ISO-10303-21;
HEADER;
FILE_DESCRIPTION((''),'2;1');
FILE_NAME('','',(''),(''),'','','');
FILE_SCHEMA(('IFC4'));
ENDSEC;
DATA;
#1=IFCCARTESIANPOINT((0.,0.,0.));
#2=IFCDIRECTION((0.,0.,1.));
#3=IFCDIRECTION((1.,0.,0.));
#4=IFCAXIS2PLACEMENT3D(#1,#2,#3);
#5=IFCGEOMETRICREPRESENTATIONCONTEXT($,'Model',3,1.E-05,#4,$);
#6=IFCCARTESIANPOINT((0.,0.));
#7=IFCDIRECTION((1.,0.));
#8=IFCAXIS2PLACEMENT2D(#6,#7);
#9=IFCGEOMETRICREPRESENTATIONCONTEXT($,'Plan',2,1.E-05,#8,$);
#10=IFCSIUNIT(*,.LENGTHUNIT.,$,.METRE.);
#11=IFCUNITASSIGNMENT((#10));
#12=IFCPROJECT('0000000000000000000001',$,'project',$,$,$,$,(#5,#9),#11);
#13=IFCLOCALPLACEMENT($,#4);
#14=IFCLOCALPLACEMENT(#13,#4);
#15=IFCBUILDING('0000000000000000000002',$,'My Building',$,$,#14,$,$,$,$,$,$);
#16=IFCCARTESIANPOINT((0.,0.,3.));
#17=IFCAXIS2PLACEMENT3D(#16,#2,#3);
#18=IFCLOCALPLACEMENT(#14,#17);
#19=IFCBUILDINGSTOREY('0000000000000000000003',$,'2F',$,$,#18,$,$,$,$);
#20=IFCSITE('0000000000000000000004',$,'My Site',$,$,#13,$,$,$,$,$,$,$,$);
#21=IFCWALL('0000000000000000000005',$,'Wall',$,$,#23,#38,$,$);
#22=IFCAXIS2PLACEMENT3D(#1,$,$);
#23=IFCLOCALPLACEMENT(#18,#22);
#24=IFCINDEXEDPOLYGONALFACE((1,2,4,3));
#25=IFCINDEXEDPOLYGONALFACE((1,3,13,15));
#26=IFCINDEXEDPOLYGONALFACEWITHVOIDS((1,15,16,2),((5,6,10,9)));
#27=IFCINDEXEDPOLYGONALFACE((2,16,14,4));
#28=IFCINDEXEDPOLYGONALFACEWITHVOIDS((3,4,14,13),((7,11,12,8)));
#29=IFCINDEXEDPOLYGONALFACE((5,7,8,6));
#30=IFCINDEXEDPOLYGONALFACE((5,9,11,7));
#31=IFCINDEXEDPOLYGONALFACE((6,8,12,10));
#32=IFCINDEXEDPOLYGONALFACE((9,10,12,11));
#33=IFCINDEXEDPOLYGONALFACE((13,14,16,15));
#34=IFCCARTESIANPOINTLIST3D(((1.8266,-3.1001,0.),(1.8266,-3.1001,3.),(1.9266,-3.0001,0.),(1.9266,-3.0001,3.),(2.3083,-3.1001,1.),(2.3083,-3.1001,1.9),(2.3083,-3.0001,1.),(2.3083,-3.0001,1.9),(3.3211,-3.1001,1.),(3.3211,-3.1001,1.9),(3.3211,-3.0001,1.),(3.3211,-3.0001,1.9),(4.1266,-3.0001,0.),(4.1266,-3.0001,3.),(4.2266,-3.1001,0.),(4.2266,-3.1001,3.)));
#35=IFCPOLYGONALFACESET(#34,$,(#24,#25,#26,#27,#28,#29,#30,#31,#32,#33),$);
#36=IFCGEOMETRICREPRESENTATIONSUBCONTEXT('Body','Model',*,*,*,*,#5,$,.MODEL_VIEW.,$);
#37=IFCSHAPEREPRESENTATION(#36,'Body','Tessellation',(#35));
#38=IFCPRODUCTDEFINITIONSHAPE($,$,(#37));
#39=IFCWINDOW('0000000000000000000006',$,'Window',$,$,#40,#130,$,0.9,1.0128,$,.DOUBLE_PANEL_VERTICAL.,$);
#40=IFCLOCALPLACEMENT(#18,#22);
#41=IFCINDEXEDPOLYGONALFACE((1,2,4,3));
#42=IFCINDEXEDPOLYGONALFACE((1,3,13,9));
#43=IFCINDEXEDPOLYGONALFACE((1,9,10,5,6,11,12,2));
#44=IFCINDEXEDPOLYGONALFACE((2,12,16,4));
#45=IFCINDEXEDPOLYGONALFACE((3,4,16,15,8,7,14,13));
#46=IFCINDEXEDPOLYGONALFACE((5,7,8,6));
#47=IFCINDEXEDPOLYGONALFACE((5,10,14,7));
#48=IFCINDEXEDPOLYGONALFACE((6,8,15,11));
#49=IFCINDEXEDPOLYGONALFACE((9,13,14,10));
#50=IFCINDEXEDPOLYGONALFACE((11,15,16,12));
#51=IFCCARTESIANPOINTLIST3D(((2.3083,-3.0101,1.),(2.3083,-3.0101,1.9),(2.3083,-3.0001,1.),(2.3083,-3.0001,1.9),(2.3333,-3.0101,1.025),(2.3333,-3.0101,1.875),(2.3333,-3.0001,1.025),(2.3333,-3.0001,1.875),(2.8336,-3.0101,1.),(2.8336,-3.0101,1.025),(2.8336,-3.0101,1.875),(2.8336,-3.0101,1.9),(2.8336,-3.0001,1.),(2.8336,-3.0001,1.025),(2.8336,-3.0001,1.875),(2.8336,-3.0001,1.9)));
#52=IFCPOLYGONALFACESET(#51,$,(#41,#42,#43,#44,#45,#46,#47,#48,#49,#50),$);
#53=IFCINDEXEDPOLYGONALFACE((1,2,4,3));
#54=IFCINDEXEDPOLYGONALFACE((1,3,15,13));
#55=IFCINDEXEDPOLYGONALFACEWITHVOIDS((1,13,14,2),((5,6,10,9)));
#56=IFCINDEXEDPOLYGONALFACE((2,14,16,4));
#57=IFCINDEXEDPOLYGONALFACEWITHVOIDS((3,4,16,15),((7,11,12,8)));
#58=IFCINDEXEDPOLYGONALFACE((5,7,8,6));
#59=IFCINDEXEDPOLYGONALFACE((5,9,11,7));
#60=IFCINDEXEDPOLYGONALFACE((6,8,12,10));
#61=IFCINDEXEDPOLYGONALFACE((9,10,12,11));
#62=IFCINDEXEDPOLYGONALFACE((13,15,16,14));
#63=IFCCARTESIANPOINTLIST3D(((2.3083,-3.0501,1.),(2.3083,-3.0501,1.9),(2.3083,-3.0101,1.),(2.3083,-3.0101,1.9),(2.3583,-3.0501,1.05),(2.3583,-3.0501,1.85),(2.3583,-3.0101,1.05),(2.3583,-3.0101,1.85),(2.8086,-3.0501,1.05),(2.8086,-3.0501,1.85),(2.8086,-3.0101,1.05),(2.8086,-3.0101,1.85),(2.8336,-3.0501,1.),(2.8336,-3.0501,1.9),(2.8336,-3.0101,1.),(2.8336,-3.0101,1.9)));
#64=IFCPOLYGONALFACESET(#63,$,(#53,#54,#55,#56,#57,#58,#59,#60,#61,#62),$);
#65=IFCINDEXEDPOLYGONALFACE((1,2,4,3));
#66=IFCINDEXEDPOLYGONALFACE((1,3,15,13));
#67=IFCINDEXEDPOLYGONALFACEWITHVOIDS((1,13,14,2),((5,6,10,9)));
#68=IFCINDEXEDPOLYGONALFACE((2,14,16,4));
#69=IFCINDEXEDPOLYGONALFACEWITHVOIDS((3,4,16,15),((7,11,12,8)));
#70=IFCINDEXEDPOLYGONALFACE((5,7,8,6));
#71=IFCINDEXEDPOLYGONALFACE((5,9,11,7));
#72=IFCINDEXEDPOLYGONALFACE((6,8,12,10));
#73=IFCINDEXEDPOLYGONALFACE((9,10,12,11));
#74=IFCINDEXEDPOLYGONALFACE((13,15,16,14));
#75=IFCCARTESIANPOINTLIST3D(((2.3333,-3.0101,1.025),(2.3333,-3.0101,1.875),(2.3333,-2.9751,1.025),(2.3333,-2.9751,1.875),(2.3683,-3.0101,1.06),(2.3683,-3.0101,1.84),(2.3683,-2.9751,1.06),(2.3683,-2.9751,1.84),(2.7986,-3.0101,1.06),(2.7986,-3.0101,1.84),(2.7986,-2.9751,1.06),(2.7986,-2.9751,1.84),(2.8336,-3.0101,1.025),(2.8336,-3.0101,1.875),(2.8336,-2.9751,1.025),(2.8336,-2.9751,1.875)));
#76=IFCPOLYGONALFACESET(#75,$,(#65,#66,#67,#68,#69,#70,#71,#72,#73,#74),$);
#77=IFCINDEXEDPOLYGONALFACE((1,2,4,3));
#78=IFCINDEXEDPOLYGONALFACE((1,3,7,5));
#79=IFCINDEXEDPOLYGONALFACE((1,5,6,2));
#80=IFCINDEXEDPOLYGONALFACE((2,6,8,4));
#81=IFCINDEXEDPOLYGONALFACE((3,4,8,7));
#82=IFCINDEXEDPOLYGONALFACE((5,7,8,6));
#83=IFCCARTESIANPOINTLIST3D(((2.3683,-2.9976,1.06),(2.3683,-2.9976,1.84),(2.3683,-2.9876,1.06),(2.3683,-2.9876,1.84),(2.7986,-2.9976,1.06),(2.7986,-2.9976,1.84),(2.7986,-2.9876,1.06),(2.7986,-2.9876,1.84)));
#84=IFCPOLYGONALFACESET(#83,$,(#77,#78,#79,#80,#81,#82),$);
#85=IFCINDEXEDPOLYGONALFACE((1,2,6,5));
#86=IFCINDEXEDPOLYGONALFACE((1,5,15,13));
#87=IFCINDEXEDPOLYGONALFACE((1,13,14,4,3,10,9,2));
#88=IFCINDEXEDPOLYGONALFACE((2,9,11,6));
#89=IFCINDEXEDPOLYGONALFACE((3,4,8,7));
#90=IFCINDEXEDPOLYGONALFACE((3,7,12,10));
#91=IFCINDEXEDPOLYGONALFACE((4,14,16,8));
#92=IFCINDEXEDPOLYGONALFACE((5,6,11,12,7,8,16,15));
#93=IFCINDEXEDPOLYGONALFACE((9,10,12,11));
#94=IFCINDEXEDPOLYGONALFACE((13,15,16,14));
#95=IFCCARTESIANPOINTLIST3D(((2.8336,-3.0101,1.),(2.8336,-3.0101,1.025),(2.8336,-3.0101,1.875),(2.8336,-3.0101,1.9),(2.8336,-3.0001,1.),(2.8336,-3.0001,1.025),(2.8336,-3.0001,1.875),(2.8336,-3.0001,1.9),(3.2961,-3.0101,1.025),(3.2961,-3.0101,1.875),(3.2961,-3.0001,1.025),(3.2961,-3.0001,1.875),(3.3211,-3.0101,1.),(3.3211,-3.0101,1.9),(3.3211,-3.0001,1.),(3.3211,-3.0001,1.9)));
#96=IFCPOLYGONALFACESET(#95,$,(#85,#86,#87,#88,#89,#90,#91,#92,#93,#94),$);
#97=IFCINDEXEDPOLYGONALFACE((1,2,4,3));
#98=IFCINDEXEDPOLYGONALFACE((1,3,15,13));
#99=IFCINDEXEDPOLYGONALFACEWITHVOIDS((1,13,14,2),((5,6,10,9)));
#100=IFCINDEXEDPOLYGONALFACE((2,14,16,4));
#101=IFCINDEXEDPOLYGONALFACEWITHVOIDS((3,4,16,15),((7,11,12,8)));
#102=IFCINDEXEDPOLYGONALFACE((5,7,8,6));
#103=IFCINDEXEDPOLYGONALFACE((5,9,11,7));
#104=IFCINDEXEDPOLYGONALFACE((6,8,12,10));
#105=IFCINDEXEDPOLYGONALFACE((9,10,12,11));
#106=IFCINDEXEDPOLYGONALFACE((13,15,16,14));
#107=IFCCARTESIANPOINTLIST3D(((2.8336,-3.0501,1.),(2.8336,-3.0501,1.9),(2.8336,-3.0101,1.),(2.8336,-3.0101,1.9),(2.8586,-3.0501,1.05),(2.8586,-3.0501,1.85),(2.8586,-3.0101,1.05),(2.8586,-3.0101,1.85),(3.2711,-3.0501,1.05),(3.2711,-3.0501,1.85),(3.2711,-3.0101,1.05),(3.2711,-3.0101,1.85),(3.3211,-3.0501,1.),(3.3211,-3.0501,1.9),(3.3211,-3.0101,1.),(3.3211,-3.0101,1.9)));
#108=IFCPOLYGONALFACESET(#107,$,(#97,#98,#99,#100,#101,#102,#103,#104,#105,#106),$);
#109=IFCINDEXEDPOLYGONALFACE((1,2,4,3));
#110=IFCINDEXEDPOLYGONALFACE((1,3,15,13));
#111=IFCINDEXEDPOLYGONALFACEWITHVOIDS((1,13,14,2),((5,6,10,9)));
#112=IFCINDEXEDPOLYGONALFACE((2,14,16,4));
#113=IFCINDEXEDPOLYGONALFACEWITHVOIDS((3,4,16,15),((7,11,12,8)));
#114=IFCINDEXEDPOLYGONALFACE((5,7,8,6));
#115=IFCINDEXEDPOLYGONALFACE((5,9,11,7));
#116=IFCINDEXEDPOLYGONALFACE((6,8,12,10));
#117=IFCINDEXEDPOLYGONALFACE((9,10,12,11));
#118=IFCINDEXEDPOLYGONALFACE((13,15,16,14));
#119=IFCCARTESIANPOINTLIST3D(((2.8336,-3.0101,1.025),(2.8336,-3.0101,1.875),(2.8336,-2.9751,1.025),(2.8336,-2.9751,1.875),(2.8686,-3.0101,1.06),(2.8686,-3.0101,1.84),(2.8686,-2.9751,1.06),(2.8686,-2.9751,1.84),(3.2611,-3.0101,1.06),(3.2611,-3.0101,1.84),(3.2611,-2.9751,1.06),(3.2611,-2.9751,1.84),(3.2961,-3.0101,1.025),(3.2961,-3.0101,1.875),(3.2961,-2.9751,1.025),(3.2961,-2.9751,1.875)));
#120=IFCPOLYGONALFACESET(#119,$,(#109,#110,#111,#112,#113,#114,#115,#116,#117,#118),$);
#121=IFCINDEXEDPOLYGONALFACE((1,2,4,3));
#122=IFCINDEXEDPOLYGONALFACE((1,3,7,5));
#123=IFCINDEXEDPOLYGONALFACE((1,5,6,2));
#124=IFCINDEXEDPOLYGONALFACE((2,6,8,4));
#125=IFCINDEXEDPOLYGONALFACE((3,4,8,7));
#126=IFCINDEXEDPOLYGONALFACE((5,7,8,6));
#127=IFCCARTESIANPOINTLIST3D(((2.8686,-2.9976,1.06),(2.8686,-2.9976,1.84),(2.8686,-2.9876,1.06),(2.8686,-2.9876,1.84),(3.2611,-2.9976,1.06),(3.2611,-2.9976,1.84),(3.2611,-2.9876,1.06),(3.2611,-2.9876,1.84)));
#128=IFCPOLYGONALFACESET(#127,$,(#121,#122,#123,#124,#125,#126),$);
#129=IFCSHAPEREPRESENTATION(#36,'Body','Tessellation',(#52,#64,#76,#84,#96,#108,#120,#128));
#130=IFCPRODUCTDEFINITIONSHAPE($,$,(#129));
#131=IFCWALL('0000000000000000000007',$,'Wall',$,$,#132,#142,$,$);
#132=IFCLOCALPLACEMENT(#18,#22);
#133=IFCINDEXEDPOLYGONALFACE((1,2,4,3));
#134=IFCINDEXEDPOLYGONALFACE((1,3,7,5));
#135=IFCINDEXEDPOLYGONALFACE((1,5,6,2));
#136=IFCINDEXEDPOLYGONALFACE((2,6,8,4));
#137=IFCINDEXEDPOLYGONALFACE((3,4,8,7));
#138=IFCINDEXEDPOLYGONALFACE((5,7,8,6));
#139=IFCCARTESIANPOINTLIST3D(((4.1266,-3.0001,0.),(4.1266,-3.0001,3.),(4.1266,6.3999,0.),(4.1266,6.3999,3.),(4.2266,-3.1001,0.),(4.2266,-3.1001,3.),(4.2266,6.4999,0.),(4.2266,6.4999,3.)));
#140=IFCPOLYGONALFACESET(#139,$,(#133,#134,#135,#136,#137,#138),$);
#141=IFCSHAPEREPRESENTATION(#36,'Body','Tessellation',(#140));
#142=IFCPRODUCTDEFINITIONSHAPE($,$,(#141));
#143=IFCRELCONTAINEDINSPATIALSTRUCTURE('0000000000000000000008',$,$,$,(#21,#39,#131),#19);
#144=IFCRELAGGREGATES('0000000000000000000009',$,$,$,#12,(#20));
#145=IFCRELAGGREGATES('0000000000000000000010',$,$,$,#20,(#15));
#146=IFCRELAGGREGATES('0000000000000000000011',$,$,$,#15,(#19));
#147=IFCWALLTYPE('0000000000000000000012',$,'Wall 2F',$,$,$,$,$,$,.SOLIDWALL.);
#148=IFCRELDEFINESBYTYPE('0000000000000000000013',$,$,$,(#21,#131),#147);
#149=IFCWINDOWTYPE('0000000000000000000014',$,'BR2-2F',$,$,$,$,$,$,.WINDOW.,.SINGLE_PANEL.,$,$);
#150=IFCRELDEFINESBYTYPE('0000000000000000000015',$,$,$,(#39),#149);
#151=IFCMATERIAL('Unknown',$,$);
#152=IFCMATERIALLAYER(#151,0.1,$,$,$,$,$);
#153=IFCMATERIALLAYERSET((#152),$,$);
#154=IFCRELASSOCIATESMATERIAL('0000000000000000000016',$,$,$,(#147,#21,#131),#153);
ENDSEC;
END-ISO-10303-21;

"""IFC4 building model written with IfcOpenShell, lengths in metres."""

from ifc_helpers import new_model, entity, si_unit, frame, origin_with_axes, origin_2d_with_axis, place, context, subcontext, project, spatial, line, indexed_curve, outline, extrude, shape, source, transform, mapped, material, layer, layer_set, layer_usage, type_object, type_shapes, element, fill, save


model = new_model("IFC4")

# Units and contexts
model_context = context("Model", 3, precision=1e-05, world=origin_with_axes())
plan_context = context("Plan", 2, precision=1e-05, world=origin_2d_with_axis())
body_context_1 = subcontext(model_context, "Body", "Model", "MODEL_VIEW")
body_context_2 = subcontext(plan_context, "Body", "Plan", "PLAN_VIEW")
ifc_project = project(units=[si_unit("LENGTHUNIT", "METRE")], contexts=[model_context, plan_context])

# Site, building, storey
site_placement = place(None, origin_with_axes())
site = spatial("IfcSite", under=ifc_project, at=site_placement, Name="My Site")
building_placement = place(site_placement, origin_with_axes())
building = spatial("IfcBuilding", under=site, at=building_placement, Name="My Building")
storey_placement = place(building_placement, frame((0.0, 0.0, 3.0), z_axis=(0.0, 0.0, 1.0), x_axis=(1.0, 0.0, 0.0)))
storey = spatial("IfcBuildingStorey", under=building, at=storey_placement, Name="2F")

# Shared definitions
ifc_material = material(Name="Unknown")

# Shared definitions
ifc_layer = layer(ifc_material, 0.1)
ifc_layer_set = layer_set([ifc_layer])
wall_type = type_object("IfcWallType", Name="Wall 2F", PredefinedType="SOLIDWALL", material=ifc_layer_set)

# Wall, opening, window
ifc_layer_usage_1 = layer_usage(ifc_layer_set, "AXIS2", "POSITIVE", 0.0)
wall_1_placement = place(storey_placement, frame((1.8266, -3.1001, 0.0), z_axis=(0.0, 0.0, 1.0), x_axis=(1.0, 0.0, 0.0)))
wall_1 = element("IfcWall", 1, at=wall_1_placement, inside=storey, type_object=wall_type, material=ifc_layer_usage_1, Name="Wall", context=body_context_1, shape_type="SweptSolid", body=[
    extrude(outline(indexed_curve([(0.0, 0.0), (0.1, 0.1), (2.3, 0.1), (2.4, 0.0)], segments=[line(1, 2, 3, 4, 1)])), origin_with_axes(), (0.0, 0.0, 1.0), 3.0),
])
shared_shape_1 = source(origin_with_axes(), body_context_1, "Body", "SweptSolid", [
    extrude(outline(indexed_curve([(0.0, 0.0), (1.0128, 0.0), (1.0128, 0.9), (0.0, 0.9)], segments=[line(1, 2, 3, 4, 1)])), frame((0.0, -0.6, 0.0), z_axis=(0.0, -1.0, 0.0), x_axis=(1.0, 0.0, 0.0)), (0.0, 0.0, -1.0), 1.2),
])
opening_1_placement = place(wall_1_placement, frame((0.4817, 0.0, 1.0), z_axis=(0.0, 0.0, 1.0), x_axis=(1.0, 0.0, 0.0)))
opening_1 = element("IfcOpeningElement", 2, at=opening_1_placement, cuts=wall_1, PredefinedType="OPENING", context=body_context_1, shape_type="MappedRepresentation", body=[
    mapped(shared_shape_1, transform((0.0, 0.0, 0.0), x_axis=(1.0, 0.0, 0.0), y_axis=(0.0, 1.0, 0.0), z_axis=(0.0, 0.0, 1.0), scale=1.0)),
])
window_type = type_object("IfcWindowType", Name="BR2-2F", PartitioningType="SINGLE_PANEL", PredefinedType="WINDOW")
shared_shape_2 = source(origin_with_axes(), body_context_1, "Body", "SweptSolid", [
    extrude(outline(indexed_curve([(0.5254, 0.0), (0.0, 0.0), (0.0, 0.9), (0.5254, 0.9), (0.5254, 0.875), (0.025, 0.875), (0.025, 0.025), (0.5254, 0.025)], segments=[line(1, 2, 3, 4, 5, 6, 7, 8, 1)])), frame((0.0, 0.09, 0.0), z_axis=(0.0, -1.0, 0.0), x_axis=(1.0, 0.0, 0.0)), (0.0, 0.0, -1.0), 0.01),
    extrude(outline(indexed_curve([(0.0, 0.0), (0.5254, 0.0), (0.5254, 0.9), (0.0, 0.9)], segments=[line(1, 2, 3, 4, 1)]), holes=[indexed_curve([(0.05, 0.05), (0.5004, 0.05), (0.5004, 0.85), (0.05, 0.85)], segments=[line(1, 2, 3, 4, 1)])]), frame((0.0, 0.05, 0.0), z_axis=(0.0, -1.0, 0.0), x_axis=(1.0, 0.0, 0.0)), (0.0, 0.0, -1.0), 0.04),
    extrude(outline(indexed_curve([(0.0, 0.0), (0.5004, 0.0), (0.5004, 0.85), (0.0, 0.85)], segments=[line(1, 2, 3, 4, 1)]), holes=[indexed_curve([(0.035, 0.035), (0.4654, 0.035), (0.4654, 0.815), (0.035, 0.815)], segments=[line(1, 2, 3, 4, 1)])]), frame((0.025, 0.09, 0.025), z_axis=(0.0, -1.0, 0.0), x_axis=(1.0, 0.0, 0.0)), (0.0, 0.0, -1.0), 0.035),
    extrude(outline(indexed_curve([(0.035, 0.035), (0.4654, 0.035), (0.4654, 0.815), (0.035, 0.815)], segments=[line(1, 2, 3, 4, 1)])), frame((0.025, 0.1025, 0.025), z_axis=(0.0, -1.0, 0.0), x_axis=(1.0, 0.0, 0.0)), (0.0, 0.0, -1.0), 0.01),
    extrude(outline(indexed_curve([(0.0, 0.9), (0.4875, 0.9), (0.4875, 0.0), (0.0, 0.0), (0.0, 0.025), (0.4625, 0.025), (0.4625, 0.875), (0.0, 0.875)], segments=[line(1, 2, 3, 4, 5, 6, 7, 8, 1)])), frame((0.5254, 0.09, 0.0), z_axis=(0.0, -1.0, 0.0), x_axis=(1.0, 0.0, 0.0)), (0.0, 0.0, -1.0), 0.01),
    extrude(outline(indexed_curve([(0.0, 0.0), (0.4875, 0.0), (0.4875, 0.9), (0.0, 0.9)], segments=[line(1, 2, 3, 4, 1)]), holes=[indexed_curve([(0.025, 0.05), (0.4375, 0.05), (0.4375, 0.85), (0.025, 0.85)], segments=[line(1, 2, 3, 4, 1)])]), frame((0.5254, 0.05, 0.0), z_axis=(0.0, -1.0, 0.0), x_axis=(1.0, 0.0, 0.0)), (0.0, 0.0, -1.0), 0.04),
    extrude(outline(indexed_curve([(0.0, 0.0), (0.4625, 0.0), (0.4625, 0.85), (0.0, 0.85)], segments=[line(1, 2, 3, 4, 1)]), holes=[indexed_curve([(0.035, 0.035), (0.4275, 0.035), (0.4275, 0.815), (0.035, 0.815)], segments=[line(1, 2, 3, 4, 1)])]), frame((0.5254, 0.09, 0.025), z_axis=(0.0, -1.0, 0.0), x_axis=(1.0, 0.0, 0.0)), (0.0, 0.0, -1.0), 0.035),
    extrude(outline(indexed_curve([(0.035, 0.035), (0.4275, 0.035), (0.4275, 0.815), (0.035, 0.815)], segments=[line(1, 2, 3, 4, 1)])), frame((0.5254, 0.1025, 0.025), z_axis=(0.0, -1.0, 0.0), x_axis=(1.0, 0.0, 0.0)), (0.0, 0.0, -1.0), 0.01),
])
shared_shape_3 = source(origin_with_axes(), body_context_2, "Body", "Curve2D", [
    entity("IfcIndexedPolyCurve", entity("IfcCartesianPointList2D", [[0.05, 0.05], [0.5004, 0.05]])),
    entity("IfcIndexedPolyCurve", entity("IfcCartesianPointList2D", [[0.0, 0.1], [0.025, 0.1], [0.025, 0.09], [0.05, 0.09], [0.05, 0.05], [0.0, 0.05]]), [entity("IfcLineIndex", [1, 2, 3, 4, 5, 6, 1])]),
    entity("IfcIndexedPolyCurve", entity("IfcCartesianPointList2D", [[0.5254, 0.1], [0.5254, 0.1], [0.5254, 0.09], [0.5004, 0.09], [0.5004, 0.05], [0.5254, 0.05]])),
    entity("IfcIndexedPolyCurve", entity("IfcCartesianPointList2D", [[0.025, 0.09], [0.06, 0.09], [0.06, 0.125], [0.025, 0.125]]), [entity("IfcLineIndex", [1, 2, 3, 4, 1])]),
    entity("IfcIndexedPolyCurve", entity("IfcCartesianPointList2D", [[0.5254, 0.09], [0.4904, 0.09], [0.4904, 0.125], [0.5254, 0.125]]), [entity("IfcLineIndex", [1, 2, 3, 4, 1])]),
    entity("IfcIndexedPolyCurve", entity("IfcCartesianPointList2D", [[0.06, 0.09], [0.4904, 0.09]])),
    entity("IfcIndexedPolyCurve", entity("IfcCartesianPointList2D", [[0.06, 0.125], [0.4904, 0.125]])),
    entity("IfcIndexedPolyCurve", entity("IfcCartesianPointList2D", [[0.06, 0.1075], [0.4904, 0.1075]])),
    entity("IfcIndexedPolyCurve", entity("IfcCartesianPointList2D", [[0.5504, 0.05], [0.9628, 0.05]])),
    entity("IfcIndexedPolyCurve", entity("IfcCartesianPointList2D", [[0.5254, 0.1], [0.5254, 0.1], [0.5254, 0.09], [0.5504, 0.09], [0.5504, 0.05], [0.5254, 0.05]])),
    entity("IfcIndexedPolyCurve", entity("IfcCartesianPointList2D", [[1.0128, 0.1], [0.9878, 0.1], [0.9878, 0.09], [0.9628, 0.09], [0.9628, 0.05], [1.0128, 0.05]]), [entity("IfcLineIndex", [1, 2, 3, 4, 5, 6, 1])]),
    entity("IfcIndexedPolyCurve", entity("IfcCartesianPointList2D", [[0.5254, 0.09], [0.5604, 0.09], [0.5604, 0.125], [0.5254, 0.125]]), [entity("IfcLineIndex", [1, 2, 3, 4, 1])]),
    entity("IfcIndexedPolyCurve", entity("IfcCartesianPointList2D", [[0.9878, 0.09], [0.9528, 0.09], [0.9528, 0.125], [0.9878, 0.125]]), [entity("IfcLineIndex", [1, 2, 3, 4, 1])]),
    entity("IfcIndexedPolyCurve", entity("IfcCartesianPointList2D", [[0.5604, 0.09], [0.9528, 0.09]])),
    entity("IfcIndexedPolyCurve", entity("IfcCartesianPointList2D", [[0.5604, 0.125], [0.9528, 0.125]])),
    entity("IfcIndexedPolyCurve", entity("IfcCartesianPointList2D", [[0.5604, 0.1075], [0.9528, 0.1075]])),
])
type_shapes(window_type, [shared_shape_2, shared_shape_3])
window_placement = place(opening_1_placement, frame((0.0, 0.0, 0.0), z_axis=(0.0, 0.0, 1.0), x_axis=(1.0, 0.0, 0.0)))
window = element("IfcWindow", 3, at=window_placement, inside=storey, type_object=window_type, Name="Window", OverallHeight=0.9, OverallWidth=1.0128, PartitioningType="DOUBLE_PANEL_VERTICAL", shapes=[
    shape(body_context_1, "Body", "MappedRepresentation", [mapped(shared_shape_2, transform((0.0, 0.0, 0.0), x_axis=(1.0, 0.0, 0.0), y_axis=(0.0, 1.0, 0.0), z_axis=(0.0, 0.0, 1.0), scale=1.0))]),
    shape(body_context_2, "Body", "MappedRepresentation", [mapped(shared_shape_3, transform((0.0, 0.0, 0.0), x_axis=(1.0, 0.0, 0.0), y_axis=(0.0, 1.0, 0.0), z_axis=(0.0, 0.0, 1.0), scale=1.0))]),
])
fill(opening_1, window)

# Wall
ifc_layer_usage_2 = layer_usage(ifc_layer_set, "AXIS2", "POSITIVE", 0.0)
wall_2_placement = place(storey_placement, frame((4.2266, -3.1001, 0.0), z_axis=(0.0, 0.0, 1.0), x_axis=(0.0, 1.0, 0.0)))
element("IfcWall", 4, at=wall_2_placement, inside=storey, type_object=wall_type, material=ifc_layer_usage_2, Name="Wall", context=body_context_1, shape_type="SweptSolid", body=[
    extrude(outline(indexed_curve([(0.0, 0.0), (0.1, 0.1), (9.5, 0.1), (9.6, 0.0)], segments=[line(1, 2, 3, 4, 1)])), origin_with_axes(), (0.0, 0.0, 1.0), 3.0),
])

save(model, "model.ifc")
